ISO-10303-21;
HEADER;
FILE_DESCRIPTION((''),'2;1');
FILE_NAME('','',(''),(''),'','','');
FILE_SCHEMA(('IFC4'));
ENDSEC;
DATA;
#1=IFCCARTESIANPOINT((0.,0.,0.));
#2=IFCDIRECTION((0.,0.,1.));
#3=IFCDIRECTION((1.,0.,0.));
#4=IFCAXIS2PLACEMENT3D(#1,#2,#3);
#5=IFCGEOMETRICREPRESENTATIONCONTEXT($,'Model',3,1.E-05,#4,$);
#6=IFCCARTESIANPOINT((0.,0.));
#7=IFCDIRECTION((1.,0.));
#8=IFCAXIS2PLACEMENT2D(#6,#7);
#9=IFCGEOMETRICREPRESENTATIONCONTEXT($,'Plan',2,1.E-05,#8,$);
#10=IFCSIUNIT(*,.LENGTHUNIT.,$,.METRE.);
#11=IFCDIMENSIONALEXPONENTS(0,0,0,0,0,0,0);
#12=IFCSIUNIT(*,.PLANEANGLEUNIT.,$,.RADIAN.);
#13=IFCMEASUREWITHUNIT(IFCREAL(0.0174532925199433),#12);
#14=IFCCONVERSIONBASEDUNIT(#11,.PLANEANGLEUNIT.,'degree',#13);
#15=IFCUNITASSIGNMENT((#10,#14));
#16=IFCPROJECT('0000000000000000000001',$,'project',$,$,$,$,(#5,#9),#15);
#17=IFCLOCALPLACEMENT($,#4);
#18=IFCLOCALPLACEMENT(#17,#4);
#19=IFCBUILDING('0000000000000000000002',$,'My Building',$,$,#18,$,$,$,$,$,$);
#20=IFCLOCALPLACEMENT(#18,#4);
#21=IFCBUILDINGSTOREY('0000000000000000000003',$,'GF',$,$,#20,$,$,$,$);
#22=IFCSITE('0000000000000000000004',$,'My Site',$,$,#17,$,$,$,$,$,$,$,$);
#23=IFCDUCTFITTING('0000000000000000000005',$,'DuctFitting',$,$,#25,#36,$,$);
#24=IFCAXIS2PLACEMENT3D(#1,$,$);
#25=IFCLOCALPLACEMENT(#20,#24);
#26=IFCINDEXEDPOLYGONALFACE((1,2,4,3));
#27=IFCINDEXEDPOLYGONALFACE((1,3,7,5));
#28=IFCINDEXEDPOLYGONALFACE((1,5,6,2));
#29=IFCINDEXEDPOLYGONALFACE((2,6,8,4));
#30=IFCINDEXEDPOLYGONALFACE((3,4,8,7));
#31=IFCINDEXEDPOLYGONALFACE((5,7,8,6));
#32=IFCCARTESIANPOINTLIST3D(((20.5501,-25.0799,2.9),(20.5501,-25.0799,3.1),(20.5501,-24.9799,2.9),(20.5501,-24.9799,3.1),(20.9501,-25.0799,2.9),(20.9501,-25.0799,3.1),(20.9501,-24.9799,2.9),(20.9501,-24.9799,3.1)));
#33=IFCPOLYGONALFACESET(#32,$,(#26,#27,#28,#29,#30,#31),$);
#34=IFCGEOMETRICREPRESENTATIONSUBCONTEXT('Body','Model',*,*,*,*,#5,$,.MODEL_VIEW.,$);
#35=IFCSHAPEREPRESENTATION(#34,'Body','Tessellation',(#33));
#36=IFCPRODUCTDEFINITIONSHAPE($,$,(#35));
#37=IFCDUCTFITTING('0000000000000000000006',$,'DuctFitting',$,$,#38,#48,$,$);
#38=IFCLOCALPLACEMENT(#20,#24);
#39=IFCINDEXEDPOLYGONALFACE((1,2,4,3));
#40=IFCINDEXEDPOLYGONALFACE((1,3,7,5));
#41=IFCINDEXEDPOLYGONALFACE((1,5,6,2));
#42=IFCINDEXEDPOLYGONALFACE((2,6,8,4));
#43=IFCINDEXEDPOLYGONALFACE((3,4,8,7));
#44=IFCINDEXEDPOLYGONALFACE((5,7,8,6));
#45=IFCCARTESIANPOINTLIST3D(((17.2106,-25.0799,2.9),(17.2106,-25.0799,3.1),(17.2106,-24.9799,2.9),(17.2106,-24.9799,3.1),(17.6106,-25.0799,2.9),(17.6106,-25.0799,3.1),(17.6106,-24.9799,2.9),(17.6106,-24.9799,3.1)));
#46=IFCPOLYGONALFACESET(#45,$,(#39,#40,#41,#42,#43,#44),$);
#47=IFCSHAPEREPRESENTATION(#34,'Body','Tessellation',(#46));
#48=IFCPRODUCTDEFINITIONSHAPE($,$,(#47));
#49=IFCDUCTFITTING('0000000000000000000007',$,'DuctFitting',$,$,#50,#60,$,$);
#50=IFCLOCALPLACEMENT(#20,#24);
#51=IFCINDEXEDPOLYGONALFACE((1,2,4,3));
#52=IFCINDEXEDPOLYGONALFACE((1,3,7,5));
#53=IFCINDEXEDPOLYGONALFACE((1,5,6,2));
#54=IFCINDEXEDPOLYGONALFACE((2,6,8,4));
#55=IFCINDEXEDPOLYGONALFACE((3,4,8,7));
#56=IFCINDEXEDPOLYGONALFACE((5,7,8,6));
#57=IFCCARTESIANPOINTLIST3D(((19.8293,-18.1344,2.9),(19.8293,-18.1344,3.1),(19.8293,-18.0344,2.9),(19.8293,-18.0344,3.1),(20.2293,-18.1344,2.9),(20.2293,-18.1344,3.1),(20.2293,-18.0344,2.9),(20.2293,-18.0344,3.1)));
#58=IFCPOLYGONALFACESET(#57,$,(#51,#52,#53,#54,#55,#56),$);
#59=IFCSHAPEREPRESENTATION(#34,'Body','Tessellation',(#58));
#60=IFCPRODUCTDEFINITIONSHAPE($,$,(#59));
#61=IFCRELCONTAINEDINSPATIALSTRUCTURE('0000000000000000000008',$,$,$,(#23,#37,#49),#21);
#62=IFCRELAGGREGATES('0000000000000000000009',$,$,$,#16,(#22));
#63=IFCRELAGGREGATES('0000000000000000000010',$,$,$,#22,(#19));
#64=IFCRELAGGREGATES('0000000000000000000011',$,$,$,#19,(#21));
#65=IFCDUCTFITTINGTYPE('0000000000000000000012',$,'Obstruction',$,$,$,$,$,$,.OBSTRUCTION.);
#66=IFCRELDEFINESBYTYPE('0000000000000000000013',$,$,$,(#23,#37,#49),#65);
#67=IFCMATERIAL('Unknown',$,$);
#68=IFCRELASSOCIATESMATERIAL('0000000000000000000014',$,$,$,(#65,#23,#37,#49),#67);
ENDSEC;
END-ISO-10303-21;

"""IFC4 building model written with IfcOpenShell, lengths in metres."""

from ifc_helpers import new_model, entity, si_unit, converted_unit, frame, origin_with_axes, origin_2d_with_axis, place, context, subcontext, project, spatial, rectangle, extrude, material, material_profile, profile_set, profile_usage, type_object, element, save


model = new_model("IFC4")

# Units and contexts
model_context = context("Model", 3, precision=1e-05, world=origin_with_axes())
plan_context = context("Plan", 2, precision=1e-05, world=origin_2d_with_axis())
body_context_1 = subcontext(model_context, "Body", "Model", "MODEL_VIEW")
ifc_project = project(units=[si_unit("LENGTHUNIT", "METRE"), converted_unit("PLANEANGLEUNIT", "degree", entity("IfcReal", 0.0174532925199433), si_unit("PLANEANGLEUNIT", "RADIAN"), dimensions=[0, 0, 0, 0, 0, 0, 0])], contexts=[model_context, plan_context])

# Site, building, storey
site_placement = place(None, origin_with_axes())
site = spatial("IfcSite", under=ifc_project, at=site_placement, Name="My Site")
building_placement = place(site_placement, origin_with_axes())
building = spatial("IfcBuilding", under=site, at=building_placement, Name="My Building")
storey_placement = place(building_placement, origin_with_axes())
storey = spatial("IfcBuildingStorey", under=building, at=storey_placement, Name="GF")

# Shared definitions
ifc_material = material(Name="Unknown")

# Duct fittings
ifc_material_profile_1 = material_profile(ifc_material, rectangle(XDim=0.4, YDim=0.2))
ifc_profile_set_1 = profile_set([ifc_material_profile_1])
duct_fitting_type_1 = type_object("IfcDuctFittingType", Name="Obstruction", PredefinedType="OBSTRUCTION", material=ifc_profile_set_1)
ifc_profile_usage_1 = profile_usage(ifc_profile_set_1, cardinal=5)
duct_fitting_1_placement = place(storey_placement, frame((20.7501, -24.9799, 3.0), z_axis=(0.0, -1.0, 0.0), x_axis=(1.0, 0.0, 0.0)))
element("IfcDuctFitting", 1, at=duct_fitting_1_placement, inside=storey, type_object=duct_fitting_type_1, material=ifc_profile_usage_1, Name="DuctFitting", context=body_context_1, shape_type="SweptSolid", body=[
    extrude(rectangle(XDim=0.4, YDim=0.2), origin_with_axes(), (0.0, 0.0, 1.0), 0.1),
])
ifc_profile_usage_2 = profile_usage(ifc_profile_set_1, cardinal=5)
duct_fitting_2_placement = place(storey_placement, frame((17.4106, -24.9799, 3.0), z_axis=(0.0, -1.0, 0.0), x_axis=(1.0, 0.0, 0.0)))
element("IfcDuctFitting", 2, at=duct_fitting_2_placement, inside=storey, type_object=duct_fitting_type_1, material=ifc_profile_usage_2, Name="DuctFitting", context=body_context_1, shape_type="SweptSolid", body=[
    extrude(rectangle(XDim=0.4, YDim=0.2), origin_with_axes(), (0.0, 0.0, 1.0), 0.1),
])
ifc_profile_usage_3 = profile_usage(ifc_profile_set_1, cardinal=5)
duct_fitting_3_placement = place(storey_placement, frame((20.0293, -18.0344, 3.0), z_axis=(0.0, -1.0, 0.0), x_axis=(1.0, 0.0, 0.0)))
element("IfcDuctFitting", 3, at=duct_fitting_3_placement, inside=storey, type_object=duct_fitting_type_1, material=ifc_profile_usage_3, Name="DuctFitting", context=body_context_1, shape_type="SweptSolid", body=[
    extrude(rectangle(XDim=0.4, YDim=0.2), origin_with_axes(), (0.0, 0.0, 1.0), 0.1),
])

save(model, "model.ifc")
